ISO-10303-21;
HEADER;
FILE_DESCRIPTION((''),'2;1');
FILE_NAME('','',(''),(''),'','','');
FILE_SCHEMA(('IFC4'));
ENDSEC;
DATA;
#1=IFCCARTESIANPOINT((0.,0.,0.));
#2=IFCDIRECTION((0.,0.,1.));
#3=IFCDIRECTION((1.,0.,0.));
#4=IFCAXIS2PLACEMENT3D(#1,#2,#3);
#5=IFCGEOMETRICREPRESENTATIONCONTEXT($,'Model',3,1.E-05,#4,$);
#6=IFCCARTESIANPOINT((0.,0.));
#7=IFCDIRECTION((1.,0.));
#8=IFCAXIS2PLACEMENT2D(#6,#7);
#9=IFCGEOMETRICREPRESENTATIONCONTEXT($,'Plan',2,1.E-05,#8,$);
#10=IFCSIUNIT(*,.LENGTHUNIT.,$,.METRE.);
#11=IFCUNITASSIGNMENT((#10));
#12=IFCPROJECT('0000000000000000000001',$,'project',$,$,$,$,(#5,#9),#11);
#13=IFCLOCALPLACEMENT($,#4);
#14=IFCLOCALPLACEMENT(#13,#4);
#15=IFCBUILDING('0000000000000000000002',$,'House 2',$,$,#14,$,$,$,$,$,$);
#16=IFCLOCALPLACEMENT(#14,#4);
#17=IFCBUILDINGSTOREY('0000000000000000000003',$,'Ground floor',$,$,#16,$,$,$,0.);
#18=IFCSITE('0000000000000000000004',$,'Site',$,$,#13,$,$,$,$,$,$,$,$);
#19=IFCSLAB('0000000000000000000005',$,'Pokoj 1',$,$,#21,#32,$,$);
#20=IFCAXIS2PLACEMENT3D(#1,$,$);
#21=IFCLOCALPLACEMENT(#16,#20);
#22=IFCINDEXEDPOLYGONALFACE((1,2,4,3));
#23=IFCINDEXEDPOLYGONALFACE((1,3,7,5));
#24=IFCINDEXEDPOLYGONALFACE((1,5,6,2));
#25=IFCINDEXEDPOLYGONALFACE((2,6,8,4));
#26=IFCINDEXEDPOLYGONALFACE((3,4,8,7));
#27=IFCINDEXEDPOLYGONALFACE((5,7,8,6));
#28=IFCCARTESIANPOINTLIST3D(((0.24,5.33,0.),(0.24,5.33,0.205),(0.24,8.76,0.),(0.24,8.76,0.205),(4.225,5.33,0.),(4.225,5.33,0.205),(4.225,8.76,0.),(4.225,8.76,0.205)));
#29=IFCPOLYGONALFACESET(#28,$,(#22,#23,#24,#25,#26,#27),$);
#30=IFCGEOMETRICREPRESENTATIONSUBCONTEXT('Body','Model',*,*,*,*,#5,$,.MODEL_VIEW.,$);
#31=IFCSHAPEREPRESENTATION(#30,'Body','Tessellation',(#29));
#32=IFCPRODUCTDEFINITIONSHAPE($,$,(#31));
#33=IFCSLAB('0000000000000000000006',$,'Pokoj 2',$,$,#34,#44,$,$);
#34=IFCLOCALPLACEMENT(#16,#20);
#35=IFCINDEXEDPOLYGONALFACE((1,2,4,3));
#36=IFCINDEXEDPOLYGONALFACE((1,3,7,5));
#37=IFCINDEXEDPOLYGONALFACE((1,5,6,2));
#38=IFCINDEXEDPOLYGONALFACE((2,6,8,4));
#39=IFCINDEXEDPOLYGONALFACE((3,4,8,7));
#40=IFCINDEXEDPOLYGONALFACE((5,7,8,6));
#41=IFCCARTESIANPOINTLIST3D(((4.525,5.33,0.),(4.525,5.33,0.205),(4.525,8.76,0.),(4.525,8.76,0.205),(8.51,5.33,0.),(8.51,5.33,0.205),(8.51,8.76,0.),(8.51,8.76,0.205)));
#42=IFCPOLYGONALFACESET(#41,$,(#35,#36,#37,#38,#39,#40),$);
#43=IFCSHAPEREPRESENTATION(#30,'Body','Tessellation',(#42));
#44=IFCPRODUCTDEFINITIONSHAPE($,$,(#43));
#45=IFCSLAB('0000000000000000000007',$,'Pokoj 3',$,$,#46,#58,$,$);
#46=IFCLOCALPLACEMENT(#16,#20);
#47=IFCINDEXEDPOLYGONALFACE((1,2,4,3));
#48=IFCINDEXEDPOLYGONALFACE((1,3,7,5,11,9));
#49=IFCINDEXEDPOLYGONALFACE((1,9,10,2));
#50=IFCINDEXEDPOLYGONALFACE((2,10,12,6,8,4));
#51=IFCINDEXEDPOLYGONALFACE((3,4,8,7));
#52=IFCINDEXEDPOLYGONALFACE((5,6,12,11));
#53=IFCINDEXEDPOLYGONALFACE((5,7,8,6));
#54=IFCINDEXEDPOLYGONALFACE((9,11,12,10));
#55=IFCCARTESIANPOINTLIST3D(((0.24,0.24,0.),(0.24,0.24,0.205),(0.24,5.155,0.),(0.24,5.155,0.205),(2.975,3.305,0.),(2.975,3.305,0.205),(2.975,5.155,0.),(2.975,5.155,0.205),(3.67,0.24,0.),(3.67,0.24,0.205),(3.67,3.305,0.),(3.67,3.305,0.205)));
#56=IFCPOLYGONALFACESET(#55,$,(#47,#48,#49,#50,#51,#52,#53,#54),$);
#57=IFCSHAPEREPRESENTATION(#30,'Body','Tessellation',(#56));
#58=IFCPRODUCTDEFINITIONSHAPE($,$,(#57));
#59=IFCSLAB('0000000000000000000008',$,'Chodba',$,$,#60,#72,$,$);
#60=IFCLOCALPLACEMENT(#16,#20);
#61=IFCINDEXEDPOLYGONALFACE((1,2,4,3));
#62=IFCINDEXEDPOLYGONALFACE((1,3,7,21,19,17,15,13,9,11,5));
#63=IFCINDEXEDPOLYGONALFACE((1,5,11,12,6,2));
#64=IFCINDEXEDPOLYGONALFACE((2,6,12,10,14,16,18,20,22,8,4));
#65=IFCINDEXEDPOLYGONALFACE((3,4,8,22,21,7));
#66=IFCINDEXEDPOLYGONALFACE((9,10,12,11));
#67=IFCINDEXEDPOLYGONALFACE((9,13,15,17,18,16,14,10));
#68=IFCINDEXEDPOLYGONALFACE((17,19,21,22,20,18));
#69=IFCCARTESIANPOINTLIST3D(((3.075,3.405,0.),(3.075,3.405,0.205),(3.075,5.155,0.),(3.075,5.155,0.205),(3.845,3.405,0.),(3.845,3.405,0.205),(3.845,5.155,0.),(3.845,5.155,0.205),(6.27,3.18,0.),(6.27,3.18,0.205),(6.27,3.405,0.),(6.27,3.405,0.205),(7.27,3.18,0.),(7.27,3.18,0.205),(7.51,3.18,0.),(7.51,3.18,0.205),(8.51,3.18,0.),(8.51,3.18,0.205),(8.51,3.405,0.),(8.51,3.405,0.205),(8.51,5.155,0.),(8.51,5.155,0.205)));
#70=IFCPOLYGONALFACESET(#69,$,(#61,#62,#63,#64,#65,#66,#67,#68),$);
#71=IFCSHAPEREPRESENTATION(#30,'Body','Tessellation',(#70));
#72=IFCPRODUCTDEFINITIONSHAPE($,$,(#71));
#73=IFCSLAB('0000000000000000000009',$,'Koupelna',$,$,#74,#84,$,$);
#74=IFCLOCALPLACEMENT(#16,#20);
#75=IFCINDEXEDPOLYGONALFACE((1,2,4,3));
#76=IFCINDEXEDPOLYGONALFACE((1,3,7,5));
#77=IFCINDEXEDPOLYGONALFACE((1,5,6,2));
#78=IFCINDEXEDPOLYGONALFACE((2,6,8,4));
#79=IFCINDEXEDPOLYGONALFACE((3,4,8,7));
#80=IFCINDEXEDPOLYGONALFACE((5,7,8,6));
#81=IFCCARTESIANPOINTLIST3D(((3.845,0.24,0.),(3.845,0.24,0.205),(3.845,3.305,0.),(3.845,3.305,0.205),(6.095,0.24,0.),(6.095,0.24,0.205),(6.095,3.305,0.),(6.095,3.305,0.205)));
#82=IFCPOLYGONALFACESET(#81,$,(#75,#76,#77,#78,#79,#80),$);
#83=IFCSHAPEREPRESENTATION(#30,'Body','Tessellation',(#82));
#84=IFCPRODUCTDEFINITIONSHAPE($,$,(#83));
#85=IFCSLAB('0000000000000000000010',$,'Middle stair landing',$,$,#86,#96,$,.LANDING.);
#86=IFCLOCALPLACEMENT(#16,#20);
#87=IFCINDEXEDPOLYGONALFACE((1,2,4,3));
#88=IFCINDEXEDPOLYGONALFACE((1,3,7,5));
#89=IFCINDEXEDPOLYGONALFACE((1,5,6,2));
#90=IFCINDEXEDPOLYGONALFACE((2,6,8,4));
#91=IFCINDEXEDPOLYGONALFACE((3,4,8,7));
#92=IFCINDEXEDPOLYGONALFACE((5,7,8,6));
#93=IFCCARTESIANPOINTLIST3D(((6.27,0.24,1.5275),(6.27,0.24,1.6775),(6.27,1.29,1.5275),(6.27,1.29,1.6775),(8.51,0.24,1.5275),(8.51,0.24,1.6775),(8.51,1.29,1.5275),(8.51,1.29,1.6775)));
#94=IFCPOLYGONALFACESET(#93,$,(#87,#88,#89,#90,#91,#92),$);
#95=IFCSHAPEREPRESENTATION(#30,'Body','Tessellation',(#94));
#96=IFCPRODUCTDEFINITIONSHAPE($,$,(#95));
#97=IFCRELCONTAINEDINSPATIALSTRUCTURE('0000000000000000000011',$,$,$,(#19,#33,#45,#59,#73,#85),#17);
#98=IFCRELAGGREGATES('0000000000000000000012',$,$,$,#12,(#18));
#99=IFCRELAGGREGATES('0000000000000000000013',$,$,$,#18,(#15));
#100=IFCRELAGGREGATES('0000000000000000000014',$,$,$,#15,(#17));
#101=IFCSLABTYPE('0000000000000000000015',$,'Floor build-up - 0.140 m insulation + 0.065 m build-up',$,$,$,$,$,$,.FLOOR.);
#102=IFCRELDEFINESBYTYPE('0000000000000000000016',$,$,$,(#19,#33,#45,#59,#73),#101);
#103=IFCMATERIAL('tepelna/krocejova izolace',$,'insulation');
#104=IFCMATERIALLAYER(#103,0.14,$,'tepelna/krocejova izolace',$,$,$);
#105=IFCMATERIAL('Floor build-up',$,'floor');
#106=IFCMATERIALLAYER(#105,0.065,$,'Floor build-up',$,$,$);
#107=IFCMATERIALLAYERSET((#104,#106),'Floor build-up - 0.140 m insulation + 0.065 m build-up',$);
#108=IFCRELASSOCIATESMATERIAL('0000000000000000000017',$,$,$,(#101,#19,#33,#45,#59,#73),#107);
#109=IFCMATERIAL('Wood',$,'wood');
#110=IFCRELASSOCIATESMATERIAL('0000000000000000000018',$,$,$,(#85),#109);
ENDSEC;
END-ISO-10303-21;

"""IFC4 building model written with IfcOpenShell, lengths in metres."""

from ifc_helpers import new_model, si_unit, frame, origin_with_axes, origin_2d_with_axis, place, context, subcontext, project, spatial, indexed_curve, outline, extrude, material, layer, layer_set, layer_usage, type_object, element, save


model = new_model("IFC4")

# Units and contexts
model_context = context("Model", 3, precision=1e-05, world=origin_with_axes())
plan_context = context("Plan", 2, precision=1e-05, world=origin_2d_with_axis())
body_context_1 = subcontext(model_context, "Body", "Model", "MODEL_VIEW")
ifc_project = project(units=[si_unit("LENGTHUNIT", "METRE")], contexts=[model_context, plan_context])

# Site, building, storey
site_placement = place(None, origin_with_axes())
site = spatial("IfcSite", under=ifc_project, at=site_placement, Name="Site")
building_placement = place(site_placement, origin_with_axes())
building = spatial("IfcBuilding", under=site, at=building_placement, Name="House 2")
storey_placement = place(building_placement, origin_with_axes())
storey = spatial("IfcBuildingStorey", under=building, at=storey_placement, Name="Ground floor", Elevation=0.0)

# Slabs
ifc_material_1 = material(Name="tepelna/krocejova izolace", Category="insulation")
ifc_layer_1 = layer(ifc_material_1, 0.14, Name="tepelna/krocejova izolace")
ifc_material_2 = material(Name="Floor build-up", Category="floor")
ifc_layer_2 = layer(ifc_material_2, 0.065, Name="Floor build-up")
ifc_layer_set_1 = layer_set([ifc_layer_1, ifc_layer_2], Name="Floor build-up - 0.140 m insulation + 0.065 m build-up")
ifc_layer_usage_1 = layer_usage(ifc_layer_set_1, "AXIS3", "POSITIVE", 0.0)
slab_type = type_object("IfcSlabType", Name="Floor build-up - 0.140 m insulation + 0.065 m build-up", PredefinedType="FLOOR", material=ifc_layer_set_1)
slab_1_placement = place(storey_placement, origin_with_axes())
element("IfcSlab", 1, at=slab_1_placement, inside=storey, type_object=slab_type, material=ifc_layer_usage_1, Name="Pokoj 1", context=body_context_1, shape_type="SweptSolid", body=[
    extrude(outline(indexed_curve([(0.24, 5.33), (4.225, 5.33), (4.225, 8.76), (0.24, 8.76)])), None, (0.0, 0.0, 1.0), 0.205),
])
ifc_layer_usage_2 = layer_usage(ifc_layer_set_1, "AXIS3", "POSITIVE", 0.0)
slab_2_placement = place(storey_placement, origin_with_axes())
element("IfcSlab", 2, at=slab_2_placement, inside=storey, type_object=slab_type, material=ifc_layer_usage_2, Name="Pokoj 2", context=body_context_1, shape_type="SweptSolid", body=[
    extrude(outline(indexed_curve([(4.525, 5.33), (8.51, 5.33), (8.51, 8.76), (4.525, 8.76)])), None, (0.0, 0.0, 1.0), 0.205),
])
ifc_layer_usage_3 = layer_usage(ifc_layer_set_1, "AXIS3", "POSITIVE", 0.0)
slab_3_placement = place(storey_placement, origin_with_axes())
element("IfcSlab", 3, at=slab_3_placement, inside=storey, type_object=slab_type, material=ifc_layer_usage_3, Name="Pokoj 3", context=body_context_1, shape_type="SweptSolid", body=[
    extrude(outline(indexed_curve([(0.24, 0.24), (3.67, 0.24), (3.67, 3.305), (2.975, 3.305), (2.975, 5.155), (0.24, 5.155)])), None, (0.0, 0.0, 1.0), 0.205),
])
ifc_layer_usage_4 = layer_usage(ifc_layer_set_1, "AXIS3", "POSITIVE", 0.0)
slab_4_placement = place(storey_placement, origin_with_axes())
element("IfcSlab", 4, at=slab_4_placement, inside=storey, type_object=slab_type, material=ifc_layer_usage_4, Name="Chodba", context=body_context_1, shape_type="SweptSolid", body=[
    extrude(outline(indexed_curve([(7.51, 3.18), (7.27, 3.18), (6.27, 3.18), (6.27, 3.405), (3.845, 3.405), (3.075, 3.405), (3.075, 5.155), (3.845, 5.155), (8.51, 5.155), (8.51, 3.405), (8.51, 3.18)])), None, (0.0, 0.0, 1.0), 0.205),
])
ifc_layer_usage_5 = layer_usage(ifc_layer_set_1, "AXIS3", "POSITIVE", 0.0)
slab_5_placement = place(storey_placement, origin_with_axes())
element("IfcSlab", 5, at=slab_5_placement, inside=storey, type_object=slab_type, material=ifc_layer_usage_5, Name="Koupelna", context=body_context_1, shape_type="SweptSolid", body=[
    extrude(outline(indexed_curve([(3.845, 0.24), (6.095, 0.24), (6.095, 3.305), (3.845, 3.305)])), None, (0.0, 0.0, 1.0), 0.205),
])
ifc_material_3 = material(Name="Wood", Category="wood")
slab_6_placement = place(storey_placement, frame((6.27, 0.24, 1.5275), z_axis=(0.0, 0.0, 1.0), x_axis=(1.0, 0.0, 0.0)))
element("IfcSlab", 6, at=slab_6_placement, inside=storey, material=ifc_material_3, Name="Middle stair landing", PredefinedType="LANDING", context=body_context_1, shape_type="SweptSolid", body=[
    extrude(outline(indexed_curve([(0.0, 0.0), (2.24, 0.0), (2.24, 1.05), (0.0, 1.05)])), None, (0.0, 0.0, 1.0), 0.15),
])

save(model, "model.ifc")
